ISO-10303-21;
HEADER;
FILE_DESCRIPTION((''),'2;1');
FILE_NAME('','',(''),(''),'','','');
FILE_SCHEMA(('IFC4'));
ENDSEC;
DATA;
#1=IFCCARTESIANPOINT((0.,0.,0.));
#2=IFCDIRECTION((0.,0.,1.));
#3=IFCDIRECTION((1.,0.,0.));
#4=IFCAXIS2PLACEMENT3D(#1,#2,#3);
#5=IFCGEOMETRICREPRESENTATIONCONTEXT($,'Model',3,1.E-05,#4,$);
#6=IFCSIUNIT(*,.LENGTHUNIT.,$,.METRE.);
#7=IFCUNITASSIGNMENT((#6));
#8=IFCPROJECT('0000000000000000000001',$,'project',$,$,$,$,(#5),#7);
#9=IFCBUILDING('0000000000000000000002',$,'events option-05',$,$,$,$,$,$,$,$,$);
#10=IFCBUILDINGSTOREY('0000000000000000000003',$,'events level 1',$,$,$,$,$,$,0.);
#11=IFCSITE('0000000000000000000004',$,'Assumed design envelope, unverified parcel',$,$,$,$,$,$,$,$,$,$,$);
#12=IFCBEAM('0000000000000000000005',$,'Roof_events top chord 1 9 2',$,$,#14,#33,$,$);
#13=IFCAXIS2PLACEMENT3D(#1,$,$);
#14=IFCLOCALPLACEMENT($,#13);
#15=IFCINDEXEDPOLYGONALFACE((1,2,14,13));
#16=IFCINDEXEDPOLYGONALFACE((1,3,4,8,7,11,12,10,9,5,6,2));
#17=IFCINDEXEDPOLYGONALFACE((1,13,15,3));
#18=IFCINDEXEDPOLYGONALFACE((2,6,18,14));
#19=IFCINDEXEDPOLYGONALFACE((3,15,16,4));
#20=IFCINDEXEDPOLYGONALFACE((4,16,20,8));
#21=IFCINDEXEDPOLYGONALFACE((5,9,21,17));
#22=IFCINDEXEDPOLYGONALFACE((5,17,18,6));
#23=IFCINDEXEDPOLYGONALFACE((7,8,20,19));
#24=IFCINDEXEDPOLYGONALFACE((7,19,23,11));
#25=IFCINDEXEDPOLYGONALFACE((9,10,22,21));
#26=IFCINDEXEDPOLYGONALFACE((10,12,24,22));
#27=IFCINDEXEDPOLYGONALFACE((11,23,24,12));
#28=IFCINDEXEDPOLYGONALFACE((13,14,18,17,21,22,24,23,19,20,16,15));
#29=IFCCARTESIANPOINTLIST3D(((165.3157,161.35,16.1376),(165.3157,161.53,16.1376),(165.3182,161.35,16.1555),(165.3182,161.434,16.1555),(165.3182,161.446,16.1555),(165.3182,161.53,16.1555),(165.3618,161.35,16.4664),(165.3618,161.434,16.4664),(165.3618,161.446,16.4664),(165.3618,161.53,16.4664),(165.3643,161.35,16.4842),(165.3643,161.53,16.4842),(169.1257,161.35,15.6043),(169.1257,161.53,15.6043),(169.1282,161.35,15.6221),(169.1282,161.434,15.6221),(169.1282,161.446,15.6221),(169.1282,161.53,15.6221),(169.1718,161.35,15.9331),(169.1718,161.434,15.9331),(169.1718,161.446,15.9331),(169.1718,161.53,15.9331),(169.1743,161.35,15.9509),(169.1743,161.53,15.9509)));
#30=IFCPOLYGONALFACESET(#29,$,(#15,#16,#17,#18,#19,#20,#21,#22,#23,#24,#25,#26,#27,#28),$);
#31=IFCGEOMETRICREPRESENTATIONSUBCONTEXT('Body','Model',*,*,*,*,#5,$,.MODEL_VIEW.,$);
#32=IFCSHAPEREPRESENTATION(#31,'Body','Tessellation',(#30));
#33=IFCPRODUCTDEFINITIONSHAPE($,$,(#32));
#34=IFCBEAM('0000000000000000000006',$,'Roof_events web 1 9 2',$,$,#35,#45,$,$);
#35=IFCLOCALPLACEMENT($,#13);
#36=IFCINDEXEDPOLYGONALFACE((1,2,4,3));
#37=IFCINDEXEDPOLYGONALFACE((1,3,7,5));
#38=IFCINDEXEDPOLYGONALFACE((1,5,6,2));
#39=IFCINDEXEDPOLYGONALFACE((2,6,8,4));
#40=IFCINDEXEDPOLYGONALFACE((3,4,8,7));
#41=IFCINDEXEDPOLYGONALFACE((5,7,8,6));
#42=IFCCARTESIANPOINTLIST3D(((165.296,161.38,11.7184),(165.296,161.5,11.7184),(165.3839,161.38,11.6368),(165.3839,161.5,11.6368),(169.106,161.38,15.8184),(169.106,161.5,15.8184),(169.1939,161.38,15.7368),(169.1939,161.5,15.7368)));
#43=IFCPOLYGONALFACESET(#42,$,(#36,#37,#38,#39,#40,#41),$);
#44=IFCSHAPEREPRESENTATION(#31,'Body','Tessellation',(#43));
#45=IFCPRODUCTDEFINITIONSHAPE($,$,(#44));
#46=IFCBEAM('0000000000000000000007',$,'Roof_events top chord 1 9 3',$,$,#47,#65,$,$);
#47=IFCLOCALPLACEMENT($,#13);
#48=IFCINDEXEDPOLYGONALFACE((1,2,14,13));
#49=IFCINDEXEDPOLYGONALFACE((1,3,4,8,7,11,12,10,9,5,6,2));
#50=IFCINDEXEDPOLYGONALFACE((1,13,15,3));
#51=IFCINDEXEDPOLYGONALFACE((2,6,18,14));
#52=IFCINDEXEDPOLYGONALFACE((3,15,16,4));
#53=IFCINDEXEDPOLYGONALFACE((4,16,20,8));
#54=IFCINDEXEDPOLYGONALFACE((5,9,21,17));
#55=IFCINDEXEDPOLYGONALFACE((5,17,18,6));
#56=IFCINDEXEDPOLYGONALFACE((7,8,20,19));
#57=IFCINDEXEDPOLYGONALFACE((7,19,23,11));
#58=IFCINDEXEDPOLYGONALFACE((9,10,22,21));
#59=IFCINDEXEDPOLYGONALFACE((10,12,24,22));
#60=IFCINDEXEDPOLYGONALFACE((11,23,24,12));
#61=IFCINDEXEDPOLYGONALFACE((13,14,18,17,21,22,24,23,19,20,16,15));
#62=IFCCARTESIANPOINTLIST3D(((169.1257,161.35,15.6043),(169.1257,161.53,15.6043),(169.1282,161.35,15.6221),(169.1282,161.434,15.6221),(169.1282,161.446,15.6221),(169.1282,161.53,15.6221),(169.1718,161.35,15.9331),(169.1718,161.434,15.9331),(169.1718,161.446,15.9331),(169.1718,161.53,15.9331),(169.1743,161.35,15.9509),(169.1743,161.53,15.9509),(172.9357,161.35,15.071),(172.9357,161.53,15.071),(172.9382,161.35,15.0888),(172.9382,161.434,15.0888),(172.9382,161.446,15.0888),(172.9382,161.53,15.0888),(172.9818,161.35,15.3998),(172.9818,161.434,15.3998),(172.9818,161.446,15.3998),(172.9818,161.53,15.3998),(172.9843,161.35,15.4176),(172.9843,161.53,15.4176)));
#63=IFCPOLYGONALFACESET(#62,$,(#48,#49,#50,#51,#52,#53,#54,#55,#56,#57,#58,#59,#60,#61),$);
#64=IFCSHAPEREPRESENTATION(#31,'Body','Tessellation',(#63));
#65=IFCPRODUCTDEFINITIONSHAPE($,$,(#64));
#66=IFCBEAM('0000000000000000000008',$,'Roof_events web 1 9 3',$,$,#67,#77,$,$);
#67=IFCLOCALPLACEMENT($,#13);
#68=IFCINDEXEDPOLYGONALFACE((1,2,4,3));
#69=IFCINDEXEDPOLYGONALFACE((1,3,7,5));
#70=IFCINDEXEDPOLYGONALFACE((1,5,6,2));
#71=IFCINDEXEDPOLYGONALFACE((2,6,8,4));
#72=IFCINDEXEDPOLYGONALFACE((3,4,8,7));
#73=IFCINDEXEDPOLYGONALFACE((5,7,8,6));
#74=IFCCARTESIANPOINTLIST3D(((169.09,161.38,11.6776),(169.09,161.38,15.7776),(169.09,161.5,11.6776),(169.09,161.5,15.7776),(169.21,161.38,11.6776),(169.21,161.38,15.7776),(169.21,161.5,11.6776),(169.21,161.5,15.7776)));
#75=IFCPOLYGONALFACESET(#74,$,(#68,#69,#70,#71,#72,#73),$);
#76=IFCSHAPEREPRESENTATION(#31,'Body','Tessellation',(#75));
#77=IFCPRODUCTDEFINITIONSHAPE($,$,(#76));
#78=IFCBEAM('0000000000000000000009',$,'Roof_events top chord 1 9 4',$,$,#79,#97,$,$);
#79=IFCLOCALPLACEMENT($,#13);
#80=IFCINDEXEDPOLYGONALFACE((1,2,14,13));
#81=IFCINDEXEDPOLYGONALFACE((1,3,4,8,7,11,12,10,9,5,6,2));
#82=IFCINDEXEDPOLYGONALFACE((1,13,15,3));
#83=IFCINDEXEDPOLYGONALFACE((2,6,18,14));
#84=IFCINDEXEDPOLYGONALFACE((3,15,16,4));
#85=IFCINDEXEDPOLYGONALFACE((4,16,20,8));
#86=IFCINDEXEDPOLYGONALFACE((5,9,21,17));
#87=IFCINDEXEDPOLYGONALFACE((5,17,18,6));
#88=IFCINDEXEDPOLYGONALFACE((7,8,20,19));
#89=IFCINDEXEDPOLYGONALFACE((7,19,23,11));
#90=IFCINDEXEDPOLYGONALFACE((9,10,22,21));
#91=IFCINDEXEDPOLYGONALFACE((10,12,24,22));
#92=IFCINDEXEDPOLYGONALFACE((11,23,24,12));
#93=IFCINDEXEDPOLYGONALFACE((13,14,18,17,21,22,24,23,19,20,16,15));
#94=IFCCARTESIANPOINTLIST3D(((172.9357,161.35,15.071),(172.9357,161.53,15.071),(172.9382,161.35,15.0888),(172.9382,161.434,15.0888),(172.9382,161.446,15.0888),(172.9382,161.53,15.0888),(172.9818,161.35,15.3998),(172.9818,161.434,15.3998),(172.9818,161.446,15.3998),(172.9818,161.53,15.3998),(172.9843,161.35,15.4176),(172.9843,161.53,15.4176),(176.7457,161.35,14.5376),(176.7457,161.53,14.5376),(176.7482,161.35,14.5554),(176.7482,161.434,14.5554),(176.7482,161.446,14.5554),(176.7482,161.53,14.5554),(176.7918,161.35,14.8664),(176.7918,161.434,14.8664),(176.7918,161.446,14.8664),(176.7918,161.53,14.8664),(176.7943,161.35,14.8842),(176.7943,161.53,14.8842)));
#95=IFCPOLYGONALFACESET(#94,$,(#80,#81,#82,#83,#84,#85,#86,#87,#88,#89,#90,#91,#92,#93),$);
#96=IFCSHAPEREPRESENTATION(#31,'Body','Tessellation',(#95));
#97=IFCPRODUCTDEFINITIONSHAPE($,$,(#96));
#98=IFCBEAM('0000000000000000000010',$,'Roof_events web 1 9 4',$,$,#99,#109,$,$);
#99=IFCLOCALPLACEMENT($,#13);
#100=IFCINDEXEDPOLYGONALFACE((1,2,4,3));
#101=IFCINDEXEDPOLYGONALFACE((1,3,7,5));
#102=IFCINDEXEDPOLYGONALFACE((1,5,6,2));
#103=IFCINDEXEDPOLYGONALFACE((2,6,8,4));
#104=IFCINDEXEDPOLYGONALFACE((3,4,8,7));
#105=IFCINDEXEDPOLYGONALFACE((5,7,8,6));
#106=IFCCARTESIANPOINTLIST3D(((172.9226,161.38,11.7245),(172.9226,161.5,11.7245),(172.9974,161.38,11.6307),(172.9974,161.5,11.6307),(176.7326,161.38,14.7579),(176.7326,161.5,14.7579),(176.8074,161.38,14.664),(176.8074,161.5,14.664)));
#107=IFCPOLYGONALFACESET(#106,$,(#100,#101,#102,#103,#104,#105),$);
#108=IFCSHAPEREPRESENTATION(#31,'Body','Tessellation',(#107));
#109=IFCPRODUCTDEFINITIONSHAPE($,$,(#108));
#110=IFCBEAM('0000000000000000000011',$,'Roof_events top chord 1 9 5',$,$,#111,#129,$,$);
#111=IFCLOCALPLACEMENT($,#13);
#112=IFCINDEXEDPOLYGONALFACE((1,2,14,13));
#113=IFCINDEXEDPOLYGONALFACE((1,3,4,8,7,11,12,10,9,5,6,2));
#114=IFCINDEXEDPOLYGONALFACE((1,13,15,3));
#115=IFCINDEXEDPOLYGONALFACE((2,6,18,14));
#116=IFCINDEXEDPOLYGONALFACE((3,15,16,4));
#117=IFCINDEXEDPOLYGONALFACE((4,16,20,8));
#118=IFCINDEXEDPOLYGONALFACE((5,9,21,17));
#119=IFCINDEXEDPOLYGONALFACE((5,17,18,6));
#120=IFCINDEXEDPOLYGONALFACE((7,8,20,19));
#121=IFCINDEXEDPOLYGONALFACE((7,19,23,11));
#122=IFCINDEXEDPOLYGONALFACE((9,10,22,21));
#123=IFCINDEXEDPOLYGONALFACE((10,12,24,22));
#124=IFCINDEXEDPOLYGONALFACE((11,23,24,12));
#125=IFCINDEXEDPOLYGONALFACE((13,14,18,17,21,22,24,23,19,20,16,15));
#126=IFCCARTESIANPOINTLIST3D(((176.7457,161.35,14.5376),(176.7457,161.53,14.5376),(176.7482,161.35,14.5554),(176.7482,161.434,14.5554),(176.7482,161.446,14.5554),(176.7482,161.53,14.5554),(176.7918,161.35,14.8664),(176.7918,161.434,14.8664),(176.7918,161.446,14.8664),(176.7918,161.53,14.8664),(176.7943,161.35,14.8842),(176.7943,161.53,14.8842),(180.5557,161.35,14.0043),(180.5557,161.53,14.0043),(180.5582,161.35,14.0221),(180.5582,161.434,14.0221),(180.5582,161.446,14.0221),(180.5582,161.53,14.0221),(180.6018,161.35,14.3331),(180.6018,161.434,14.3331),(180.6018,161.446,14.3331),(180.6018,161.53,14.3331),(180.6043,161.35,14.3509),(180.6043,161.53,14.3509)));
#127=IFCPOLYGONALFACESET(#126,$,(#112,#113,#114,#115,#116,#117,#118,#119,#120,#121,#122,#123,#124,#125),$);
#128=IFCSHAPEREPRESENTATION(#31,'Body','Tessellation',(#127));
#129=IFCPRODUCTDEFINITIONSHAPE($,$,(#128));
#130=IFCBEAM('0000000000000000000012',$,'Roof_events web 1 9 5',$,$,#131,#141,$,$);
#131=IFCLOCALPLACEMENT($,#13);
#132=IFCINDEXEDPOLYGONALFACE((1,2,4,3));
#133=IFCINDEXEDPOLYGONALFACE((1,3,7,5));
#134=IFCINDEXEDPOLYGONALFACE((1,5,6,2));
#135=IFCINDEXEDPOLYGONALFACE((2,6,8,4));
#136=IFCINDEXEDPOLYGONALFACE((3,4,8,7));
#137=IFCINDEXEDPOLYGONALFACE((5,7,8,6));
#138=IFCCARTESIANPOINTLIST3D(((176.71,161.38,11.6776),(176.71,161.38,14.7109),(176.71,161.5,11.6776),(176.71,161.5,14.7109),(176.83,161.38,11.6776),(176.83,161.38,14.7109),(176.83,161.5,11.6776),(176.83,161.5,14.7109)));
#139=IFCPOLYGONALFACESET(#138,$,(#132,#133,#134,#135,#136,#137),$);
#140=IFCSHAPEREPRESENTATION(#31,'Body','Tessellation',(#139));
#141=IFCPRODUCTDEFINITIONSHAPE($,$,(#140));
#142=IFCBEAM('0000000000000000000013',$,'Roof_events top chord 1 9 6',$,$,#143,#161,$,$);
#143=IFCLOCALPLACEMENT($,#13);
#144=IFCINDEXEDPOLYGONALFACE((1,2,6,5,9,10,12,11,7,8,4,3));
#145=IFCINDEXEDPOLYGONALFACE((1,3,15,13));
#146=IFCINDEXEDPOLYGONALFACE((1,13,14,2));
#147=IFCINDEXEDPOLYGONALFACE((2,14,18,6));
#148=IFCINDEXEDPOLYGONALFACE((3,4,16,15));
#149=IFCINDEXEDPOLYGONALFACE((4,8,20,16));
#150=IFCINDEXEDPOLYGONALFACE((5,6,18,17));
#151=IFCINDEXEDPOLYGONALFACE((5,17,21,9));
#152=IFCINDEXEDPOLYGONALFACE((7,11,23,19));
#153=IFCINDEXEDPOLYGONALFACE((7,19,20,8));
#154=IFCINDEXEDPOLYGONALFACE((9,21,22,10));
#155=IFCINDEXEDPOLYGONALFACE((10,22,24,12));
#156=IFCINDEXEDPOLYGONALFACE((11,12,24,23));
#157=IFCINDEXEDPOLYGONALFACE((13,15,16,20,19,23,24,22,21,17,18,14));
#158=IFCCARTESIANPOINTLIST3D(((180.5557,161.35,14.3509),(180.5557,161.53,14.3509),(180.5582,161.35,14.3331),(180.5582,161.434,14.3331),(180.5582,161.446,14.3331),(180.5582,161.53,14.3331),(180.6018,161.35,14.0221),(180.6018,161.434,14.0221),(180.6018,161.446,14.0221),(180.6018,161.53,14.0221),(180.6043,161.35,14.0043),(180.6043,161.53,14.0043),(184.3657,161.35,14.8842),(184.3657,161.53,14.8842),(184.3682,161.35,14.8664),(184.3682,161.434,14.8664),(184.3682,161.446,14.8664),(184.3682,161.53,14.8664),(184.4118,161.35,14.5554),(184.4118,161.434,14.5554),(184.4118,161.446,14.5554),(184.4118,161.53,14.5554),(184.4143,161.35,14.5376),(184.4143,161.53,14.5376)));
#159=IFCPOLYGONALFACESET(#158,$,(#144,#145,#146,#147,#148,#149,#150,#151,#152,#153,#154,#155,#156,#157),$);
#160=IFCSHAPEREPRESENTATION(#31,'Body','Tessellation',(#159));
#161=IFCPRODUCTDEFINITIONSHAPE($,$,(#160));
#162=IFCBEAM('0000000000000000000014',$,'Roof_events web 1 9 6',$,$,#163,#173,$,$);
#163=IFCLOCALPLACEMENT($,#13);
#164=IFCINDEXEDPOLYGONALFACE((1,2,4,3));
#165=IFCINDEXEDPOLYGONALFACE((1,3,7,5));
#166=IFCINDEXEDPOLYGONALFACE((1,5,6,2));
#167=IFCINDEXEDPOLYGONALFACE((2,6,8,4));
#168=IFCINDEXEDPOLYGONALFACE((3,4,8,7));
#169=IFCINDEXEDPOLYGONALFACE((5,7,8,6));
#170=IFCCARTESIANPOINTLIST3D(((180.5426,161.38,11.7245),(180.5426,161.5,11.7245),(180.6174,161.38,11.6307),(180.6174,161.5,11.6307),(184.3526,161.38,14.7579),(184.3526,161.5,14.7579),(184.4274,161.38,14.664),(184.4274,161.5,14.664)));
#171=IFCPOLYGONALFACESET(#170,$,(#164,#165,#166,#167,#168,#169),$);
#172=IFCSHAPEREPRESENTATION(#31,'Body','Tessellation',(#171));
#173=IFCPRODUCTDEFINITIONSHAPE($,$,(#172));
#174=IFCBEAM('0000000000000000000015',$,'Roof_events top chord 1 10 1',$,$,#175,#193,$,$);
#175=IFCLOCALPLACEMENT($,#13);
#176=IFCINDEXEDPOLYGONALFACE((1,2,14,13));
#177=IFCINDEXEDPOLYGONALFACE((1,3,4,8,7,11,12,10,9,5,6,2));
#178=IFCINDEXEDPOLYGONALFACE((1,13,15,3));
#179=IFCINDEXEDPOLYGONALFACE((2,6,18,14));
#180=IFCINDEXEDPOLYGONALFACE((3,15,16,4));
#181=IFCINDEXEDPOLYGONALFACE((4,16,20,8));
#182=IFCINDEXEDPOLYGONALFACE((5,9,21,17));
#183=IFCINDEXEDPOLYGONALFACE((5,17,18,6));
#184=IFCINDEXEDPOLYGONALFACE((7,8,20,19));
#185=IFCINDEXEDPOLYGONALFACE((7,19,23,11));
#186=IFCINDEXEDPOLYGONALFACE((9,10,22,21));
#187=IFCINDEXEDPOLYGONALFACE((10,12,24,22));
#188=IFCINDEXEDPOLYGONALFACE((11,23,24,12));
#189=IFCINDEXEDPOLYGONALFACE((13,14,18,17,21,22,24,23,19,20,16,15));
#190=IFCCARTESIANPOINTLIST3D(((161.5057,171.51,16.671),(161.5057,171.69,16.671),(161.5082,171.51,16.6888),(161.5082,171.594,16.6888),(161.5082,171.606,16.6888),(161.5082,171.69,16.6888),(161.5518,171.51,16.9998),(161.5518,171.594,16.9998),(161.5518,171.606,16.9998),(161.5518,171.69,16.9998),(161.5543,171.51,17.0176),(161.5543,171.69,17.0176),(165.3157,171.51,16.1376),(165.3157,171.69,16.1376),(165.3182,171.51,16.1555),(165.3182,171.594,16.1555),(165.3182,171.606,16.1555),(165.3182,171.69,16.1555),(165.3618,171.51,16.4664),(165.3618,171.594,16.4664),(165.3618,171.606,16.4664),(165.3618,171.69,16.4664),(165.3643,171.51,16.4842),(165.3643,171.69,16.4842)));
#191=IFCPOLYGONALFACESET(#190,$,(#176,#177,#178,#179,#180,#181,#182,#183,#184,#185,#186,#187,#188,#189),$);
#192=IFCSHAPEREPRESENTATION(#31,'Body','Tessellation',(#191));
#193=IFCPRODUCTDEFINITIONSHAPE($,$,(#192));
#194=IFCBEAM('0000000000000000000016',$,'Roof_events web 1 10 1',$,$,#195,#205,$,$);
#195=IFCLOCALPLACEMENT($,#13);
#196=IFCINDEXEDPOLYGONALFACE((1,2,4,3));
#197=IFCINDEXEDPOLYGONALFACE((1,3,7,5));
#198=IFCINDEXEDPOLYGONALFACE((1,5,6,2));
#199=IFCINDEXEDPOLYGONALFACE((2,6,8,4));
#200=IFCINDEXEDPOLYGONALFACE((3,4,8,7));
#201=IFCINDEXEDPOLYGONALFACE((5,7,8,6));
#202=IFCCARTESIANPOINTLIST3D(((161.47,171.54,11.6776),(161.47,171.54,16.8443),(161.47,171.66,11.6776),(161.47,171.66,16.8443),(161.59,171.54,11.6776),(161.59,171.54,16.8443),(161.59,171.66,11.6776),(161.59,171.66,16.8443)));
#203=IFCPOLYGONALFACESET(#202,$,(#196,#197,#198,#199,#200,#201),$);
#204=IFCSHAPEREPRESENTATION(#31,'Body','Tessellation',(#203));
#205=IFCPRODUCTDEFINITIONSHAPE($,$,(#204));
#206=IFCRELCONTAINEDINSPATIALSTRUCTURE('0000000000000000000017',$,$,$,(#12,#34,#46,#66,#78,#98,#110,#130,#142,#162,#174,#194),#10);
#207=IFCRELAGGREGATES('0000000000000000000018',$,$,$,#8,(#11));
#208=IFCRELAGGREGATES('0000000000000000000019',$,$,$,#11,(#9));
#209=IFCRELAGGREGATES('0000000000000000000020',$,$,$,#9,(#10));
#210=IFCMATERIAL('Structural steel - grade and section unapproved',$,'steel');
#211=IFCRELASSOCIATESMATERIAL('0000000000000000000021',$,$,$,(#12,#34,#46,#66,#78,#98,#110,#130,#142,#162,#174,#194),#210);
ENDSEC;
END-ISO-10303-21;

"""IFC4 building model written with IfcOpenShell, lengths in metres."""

from ifc_helpers import new_model, si_unit, frame, origin_with_axes, place, context, subcontext, project, spatial, rectangle, i_section, extrude, material, element, save


model = new_model("IFC4")

# Units and contexts
model_context = context("Model", 3, precision=1e-05, world=origin_with_axes())
body_context = subcontext(model_context, "Body", "Model", "MODEL_VIEW")
ifc_project = project(units=[si_unit("LENGTHUNIT", "METRE")], contexts=[model_context])

# Site, building, storey
site = spatial("IfcSite", under=ifc_project, Name="Assumed design envelope, unverified parcel")
building = spatial("IfcBuilding", under=site, Name="events option-05")
storey = spatial("IfcBuildingStorey", under=building, Name="events level 1", Elevation=0.0)

# Beams
ifc_material_1 = material(Name="Structural steel - grade and section unapproved", Category="steel")
beam_1_placement = place(None, frame((165.34, 161.44, 16.3109), z_axis=(0.990344, 0.0, -0.138631), x_axis=(0.0, 1.0, 0.0)))
element("IfcBeam", 1, at=beam_1_placement, inside=storey, material=ifc_material_1, Name="Roof_events top chord 1 9 2", context=body_context, shape_type="SweptSolid", body=[
    extrude(i_section(OverallWidth=0.18, OverallDepth=0.35, WebThickness=0.012, FlangeThickness=0.018, FilletRadius=0.0), origin_with_axes(), (0.0, 0.0, 1.0), 3.8471),
])
beam_2_placement = place(None, frame((165.34, 161.44, 11.6776), z_axis=(0.680725, 0.0, 0.732539), x_axis=(0.0, 1.0, 0.0)))
element("IfcBeam", 2, at=beam_2_placement, inside=storey, material=ifc_material_1, Name="Roof_events web 1 9 2", context=body_context, shape_type="SweptSolid", body=[
    extrude(rectangle(XDim=0.12, YDim=0.12), origin_with_axes(), (0.0, 0.0, 1.0), 5.597),
])
beam_3_placement = place(None, frame((169.15, 161.44, 15.7776), z_axis=(0.990344, 0.0, -0.138631), x_axis=(0.0, 1.0, 0.0)))
element("IfcBeam", 3, at=beam_3_placement, inside=storey, material=ifc_material_1, Name="Roof_events top chord 1 9 3", context=body_context, shape_type="SweptSolid", body=[
    extrude(i_section(OverallWidth=0.18, OverallDepth=0.35, WebThickness=0.012, FlangeThickness=0.018, FilletRadius=0.0), origin_with_axes(), (0.0, 0.0, 1.0), 3.8472),
])
beam_4_placement = place(None, frame((169.15, 161.44, 11.6776), z_axis=(0.0, 0.0, 1.0), x_axis=(-1.0, 0.0, 0.0)))
element("IfcBeam", 4, at=beam_4_placement, inside=storey, material=ifc_material_1, Name="Roof_events web 1 9 3", context=body_context, shape_type="SweptSolid", body=[
    extrude(rectangle(XDim=0.12, YDim=0.12), origin_with_axes(), (0.0, 0.0, 1.0), 4.1),
])
beam_5_placement = place(None, frame((172.96, 161.44, 15.2443), z_axis=(0.990344, 0.0, -0.138631), x_axis=(0.0, 1.0, 0.0)))
element("IfcBeam", 5, at=beam_5_placement, inside=storey, material=ifc_material_1, Name="Roof_events top chord 1 9 4", context=body_context, shape_type="SweptSolid", body=[
    extrude(i_section(OverallWidth=0.18, OverallDepth=0.35, WebThickness=0.012, FlangeThickness=0.018, FilletRadius=0.0), origin_with_axes(), (0.0, 0.0, 1.0), 3.8471),
])
beam_6_placement = place(None, frame((172.96, 161.44, 11.6776), z_axis=(0.782336, 0.0, 0.622857), x_axis=(0.0, 1.0, 0.0)))
element("IfcBeam", 6, at=beam_6_placement, inside=storey, material=ifc_material_1, Name="Roof_events web 1 9 4", context=body_context, shape_type="SweptSolid", body=[
    extrude(rectangle(XDim=0.12, YDim=0.12), origin_with_axes(), (0.0, 0.0, 1.0), 4.87),
])
beam_7_placement = place(None, frame((176.77, 161.44, 14.7109), z_axis=(0.990344, 0.0, -0.138631), x_axis=(0.0, 1.0, 0.0)))
element("IfcBeam", 7, at=beam_7_placement, inside=storey, material=ifc_material_1, Name="Roof_events top chord 1 9 5", context=body_context, shape_type="SweptSolid", body=[
    extrude(i_section(OverallWidth=0.18, OverallDepth=0.35, WebThickness=0.012, FlangeThickness=0.018, FilletRadius=0.0), origin_with_axes(), (0.0, 0.0, 1.0), 3.8471),
])
beam_8_placement = place(None, frame((176.77, 161.44, 11.6776), z_axis=(0.0, 0.0, 1.0), x_axis=(-1.0, 0.0, 0.0)))
element("IfcBeam", 8, at=beam_8_placement, inside=storey, material=ifc_material_1, Name="Roof_events web 1 9 5", context=body_context, shape_type="SweptSolid", body=[
    extrude(rectangle(XDim=0.12, YDim=0.12), origin_with_axes(), (0.0, 0.0, 1.0), 3.0333),
])
beam_9_placement = place(None, frame((180.58, 161.44, 14.1776), z_axis=(0.990344, 0.0, 0.138631), x_axis=(0.0, 1.0, 0.0)))
element("IfcBeam", 9, at=beam_9_placement, inside=storey, material=ifc_material_1, Name="Roof_events top chord 1 9 6", context=body_context, shape_type="SweptSolid", body=[
    extrude(i_section(OverallWidth=0.18, OverallDepth=0.35, WebThickness=0.012, FlangeThickness=0.018, FilletRadius=0.0), origin_with_axes(), (0.0, 0.0, 1.0), 3.8471),
])
beam_10_placement = place(None, frame((180.58, 161.44, 11.6776), z_axis=(0.782336, 0.0, 0.622857), x_axis=(0.0, 1.0, 0.0)))
element("IfcBeam", 10, at=beam_10_placement, inside=storey, material=ifc_material_1, Name="Roof_events web 1 9 6", context=body_context, shape_type="SweptSolid", body=[
    extrude(rectangle(XDim=0.12, YDim=0.12), origin_with_axes(), (0.0, 0.0, 1.0), 4.87),
])
beam_11_placement = place(None, frame((161.53, 171.6, 16.8443), z_axis=(0.990344, 0.0, -0.138631), x_axis=(0.0, 1.0, 0.0)))
element("IfcBeam", 11, at=beam_11_placement, inside=storey, material=ifc_material_1, Name="Roof_events top chord 1 10 1", context=body_context, shape_type="SweptSolid", body=[
    extrude(i_section(OverallWidth=0.18, OverallDepth=0.35, WebThickness=0.012, FlangeThickness=0.018, FilletRadius=0.0), origin_with_axes(), (0.0, 0.0, 1.0), 3.8471),
])
beam_12_placement = place(None, frame((161.53, 171.6, 11.6776), z_axis=(0.0, 0.0, 1.0), x_axis=(-1.0, 0.0, 0.0)))
element("IfcBeam", 12, at=beam_12_placement, inside=storey, material=ifc_material_1, Name="Roof_events web 1 10 1", context=body_context, shape_type="SweptSolid", body=[
    extrude(rectangle(XDim=0.12, YDim=0.12), origin_with_axes(), (0.0, 0.0, 1.0), 5.1667),
])

save(model, "model.ifc")
